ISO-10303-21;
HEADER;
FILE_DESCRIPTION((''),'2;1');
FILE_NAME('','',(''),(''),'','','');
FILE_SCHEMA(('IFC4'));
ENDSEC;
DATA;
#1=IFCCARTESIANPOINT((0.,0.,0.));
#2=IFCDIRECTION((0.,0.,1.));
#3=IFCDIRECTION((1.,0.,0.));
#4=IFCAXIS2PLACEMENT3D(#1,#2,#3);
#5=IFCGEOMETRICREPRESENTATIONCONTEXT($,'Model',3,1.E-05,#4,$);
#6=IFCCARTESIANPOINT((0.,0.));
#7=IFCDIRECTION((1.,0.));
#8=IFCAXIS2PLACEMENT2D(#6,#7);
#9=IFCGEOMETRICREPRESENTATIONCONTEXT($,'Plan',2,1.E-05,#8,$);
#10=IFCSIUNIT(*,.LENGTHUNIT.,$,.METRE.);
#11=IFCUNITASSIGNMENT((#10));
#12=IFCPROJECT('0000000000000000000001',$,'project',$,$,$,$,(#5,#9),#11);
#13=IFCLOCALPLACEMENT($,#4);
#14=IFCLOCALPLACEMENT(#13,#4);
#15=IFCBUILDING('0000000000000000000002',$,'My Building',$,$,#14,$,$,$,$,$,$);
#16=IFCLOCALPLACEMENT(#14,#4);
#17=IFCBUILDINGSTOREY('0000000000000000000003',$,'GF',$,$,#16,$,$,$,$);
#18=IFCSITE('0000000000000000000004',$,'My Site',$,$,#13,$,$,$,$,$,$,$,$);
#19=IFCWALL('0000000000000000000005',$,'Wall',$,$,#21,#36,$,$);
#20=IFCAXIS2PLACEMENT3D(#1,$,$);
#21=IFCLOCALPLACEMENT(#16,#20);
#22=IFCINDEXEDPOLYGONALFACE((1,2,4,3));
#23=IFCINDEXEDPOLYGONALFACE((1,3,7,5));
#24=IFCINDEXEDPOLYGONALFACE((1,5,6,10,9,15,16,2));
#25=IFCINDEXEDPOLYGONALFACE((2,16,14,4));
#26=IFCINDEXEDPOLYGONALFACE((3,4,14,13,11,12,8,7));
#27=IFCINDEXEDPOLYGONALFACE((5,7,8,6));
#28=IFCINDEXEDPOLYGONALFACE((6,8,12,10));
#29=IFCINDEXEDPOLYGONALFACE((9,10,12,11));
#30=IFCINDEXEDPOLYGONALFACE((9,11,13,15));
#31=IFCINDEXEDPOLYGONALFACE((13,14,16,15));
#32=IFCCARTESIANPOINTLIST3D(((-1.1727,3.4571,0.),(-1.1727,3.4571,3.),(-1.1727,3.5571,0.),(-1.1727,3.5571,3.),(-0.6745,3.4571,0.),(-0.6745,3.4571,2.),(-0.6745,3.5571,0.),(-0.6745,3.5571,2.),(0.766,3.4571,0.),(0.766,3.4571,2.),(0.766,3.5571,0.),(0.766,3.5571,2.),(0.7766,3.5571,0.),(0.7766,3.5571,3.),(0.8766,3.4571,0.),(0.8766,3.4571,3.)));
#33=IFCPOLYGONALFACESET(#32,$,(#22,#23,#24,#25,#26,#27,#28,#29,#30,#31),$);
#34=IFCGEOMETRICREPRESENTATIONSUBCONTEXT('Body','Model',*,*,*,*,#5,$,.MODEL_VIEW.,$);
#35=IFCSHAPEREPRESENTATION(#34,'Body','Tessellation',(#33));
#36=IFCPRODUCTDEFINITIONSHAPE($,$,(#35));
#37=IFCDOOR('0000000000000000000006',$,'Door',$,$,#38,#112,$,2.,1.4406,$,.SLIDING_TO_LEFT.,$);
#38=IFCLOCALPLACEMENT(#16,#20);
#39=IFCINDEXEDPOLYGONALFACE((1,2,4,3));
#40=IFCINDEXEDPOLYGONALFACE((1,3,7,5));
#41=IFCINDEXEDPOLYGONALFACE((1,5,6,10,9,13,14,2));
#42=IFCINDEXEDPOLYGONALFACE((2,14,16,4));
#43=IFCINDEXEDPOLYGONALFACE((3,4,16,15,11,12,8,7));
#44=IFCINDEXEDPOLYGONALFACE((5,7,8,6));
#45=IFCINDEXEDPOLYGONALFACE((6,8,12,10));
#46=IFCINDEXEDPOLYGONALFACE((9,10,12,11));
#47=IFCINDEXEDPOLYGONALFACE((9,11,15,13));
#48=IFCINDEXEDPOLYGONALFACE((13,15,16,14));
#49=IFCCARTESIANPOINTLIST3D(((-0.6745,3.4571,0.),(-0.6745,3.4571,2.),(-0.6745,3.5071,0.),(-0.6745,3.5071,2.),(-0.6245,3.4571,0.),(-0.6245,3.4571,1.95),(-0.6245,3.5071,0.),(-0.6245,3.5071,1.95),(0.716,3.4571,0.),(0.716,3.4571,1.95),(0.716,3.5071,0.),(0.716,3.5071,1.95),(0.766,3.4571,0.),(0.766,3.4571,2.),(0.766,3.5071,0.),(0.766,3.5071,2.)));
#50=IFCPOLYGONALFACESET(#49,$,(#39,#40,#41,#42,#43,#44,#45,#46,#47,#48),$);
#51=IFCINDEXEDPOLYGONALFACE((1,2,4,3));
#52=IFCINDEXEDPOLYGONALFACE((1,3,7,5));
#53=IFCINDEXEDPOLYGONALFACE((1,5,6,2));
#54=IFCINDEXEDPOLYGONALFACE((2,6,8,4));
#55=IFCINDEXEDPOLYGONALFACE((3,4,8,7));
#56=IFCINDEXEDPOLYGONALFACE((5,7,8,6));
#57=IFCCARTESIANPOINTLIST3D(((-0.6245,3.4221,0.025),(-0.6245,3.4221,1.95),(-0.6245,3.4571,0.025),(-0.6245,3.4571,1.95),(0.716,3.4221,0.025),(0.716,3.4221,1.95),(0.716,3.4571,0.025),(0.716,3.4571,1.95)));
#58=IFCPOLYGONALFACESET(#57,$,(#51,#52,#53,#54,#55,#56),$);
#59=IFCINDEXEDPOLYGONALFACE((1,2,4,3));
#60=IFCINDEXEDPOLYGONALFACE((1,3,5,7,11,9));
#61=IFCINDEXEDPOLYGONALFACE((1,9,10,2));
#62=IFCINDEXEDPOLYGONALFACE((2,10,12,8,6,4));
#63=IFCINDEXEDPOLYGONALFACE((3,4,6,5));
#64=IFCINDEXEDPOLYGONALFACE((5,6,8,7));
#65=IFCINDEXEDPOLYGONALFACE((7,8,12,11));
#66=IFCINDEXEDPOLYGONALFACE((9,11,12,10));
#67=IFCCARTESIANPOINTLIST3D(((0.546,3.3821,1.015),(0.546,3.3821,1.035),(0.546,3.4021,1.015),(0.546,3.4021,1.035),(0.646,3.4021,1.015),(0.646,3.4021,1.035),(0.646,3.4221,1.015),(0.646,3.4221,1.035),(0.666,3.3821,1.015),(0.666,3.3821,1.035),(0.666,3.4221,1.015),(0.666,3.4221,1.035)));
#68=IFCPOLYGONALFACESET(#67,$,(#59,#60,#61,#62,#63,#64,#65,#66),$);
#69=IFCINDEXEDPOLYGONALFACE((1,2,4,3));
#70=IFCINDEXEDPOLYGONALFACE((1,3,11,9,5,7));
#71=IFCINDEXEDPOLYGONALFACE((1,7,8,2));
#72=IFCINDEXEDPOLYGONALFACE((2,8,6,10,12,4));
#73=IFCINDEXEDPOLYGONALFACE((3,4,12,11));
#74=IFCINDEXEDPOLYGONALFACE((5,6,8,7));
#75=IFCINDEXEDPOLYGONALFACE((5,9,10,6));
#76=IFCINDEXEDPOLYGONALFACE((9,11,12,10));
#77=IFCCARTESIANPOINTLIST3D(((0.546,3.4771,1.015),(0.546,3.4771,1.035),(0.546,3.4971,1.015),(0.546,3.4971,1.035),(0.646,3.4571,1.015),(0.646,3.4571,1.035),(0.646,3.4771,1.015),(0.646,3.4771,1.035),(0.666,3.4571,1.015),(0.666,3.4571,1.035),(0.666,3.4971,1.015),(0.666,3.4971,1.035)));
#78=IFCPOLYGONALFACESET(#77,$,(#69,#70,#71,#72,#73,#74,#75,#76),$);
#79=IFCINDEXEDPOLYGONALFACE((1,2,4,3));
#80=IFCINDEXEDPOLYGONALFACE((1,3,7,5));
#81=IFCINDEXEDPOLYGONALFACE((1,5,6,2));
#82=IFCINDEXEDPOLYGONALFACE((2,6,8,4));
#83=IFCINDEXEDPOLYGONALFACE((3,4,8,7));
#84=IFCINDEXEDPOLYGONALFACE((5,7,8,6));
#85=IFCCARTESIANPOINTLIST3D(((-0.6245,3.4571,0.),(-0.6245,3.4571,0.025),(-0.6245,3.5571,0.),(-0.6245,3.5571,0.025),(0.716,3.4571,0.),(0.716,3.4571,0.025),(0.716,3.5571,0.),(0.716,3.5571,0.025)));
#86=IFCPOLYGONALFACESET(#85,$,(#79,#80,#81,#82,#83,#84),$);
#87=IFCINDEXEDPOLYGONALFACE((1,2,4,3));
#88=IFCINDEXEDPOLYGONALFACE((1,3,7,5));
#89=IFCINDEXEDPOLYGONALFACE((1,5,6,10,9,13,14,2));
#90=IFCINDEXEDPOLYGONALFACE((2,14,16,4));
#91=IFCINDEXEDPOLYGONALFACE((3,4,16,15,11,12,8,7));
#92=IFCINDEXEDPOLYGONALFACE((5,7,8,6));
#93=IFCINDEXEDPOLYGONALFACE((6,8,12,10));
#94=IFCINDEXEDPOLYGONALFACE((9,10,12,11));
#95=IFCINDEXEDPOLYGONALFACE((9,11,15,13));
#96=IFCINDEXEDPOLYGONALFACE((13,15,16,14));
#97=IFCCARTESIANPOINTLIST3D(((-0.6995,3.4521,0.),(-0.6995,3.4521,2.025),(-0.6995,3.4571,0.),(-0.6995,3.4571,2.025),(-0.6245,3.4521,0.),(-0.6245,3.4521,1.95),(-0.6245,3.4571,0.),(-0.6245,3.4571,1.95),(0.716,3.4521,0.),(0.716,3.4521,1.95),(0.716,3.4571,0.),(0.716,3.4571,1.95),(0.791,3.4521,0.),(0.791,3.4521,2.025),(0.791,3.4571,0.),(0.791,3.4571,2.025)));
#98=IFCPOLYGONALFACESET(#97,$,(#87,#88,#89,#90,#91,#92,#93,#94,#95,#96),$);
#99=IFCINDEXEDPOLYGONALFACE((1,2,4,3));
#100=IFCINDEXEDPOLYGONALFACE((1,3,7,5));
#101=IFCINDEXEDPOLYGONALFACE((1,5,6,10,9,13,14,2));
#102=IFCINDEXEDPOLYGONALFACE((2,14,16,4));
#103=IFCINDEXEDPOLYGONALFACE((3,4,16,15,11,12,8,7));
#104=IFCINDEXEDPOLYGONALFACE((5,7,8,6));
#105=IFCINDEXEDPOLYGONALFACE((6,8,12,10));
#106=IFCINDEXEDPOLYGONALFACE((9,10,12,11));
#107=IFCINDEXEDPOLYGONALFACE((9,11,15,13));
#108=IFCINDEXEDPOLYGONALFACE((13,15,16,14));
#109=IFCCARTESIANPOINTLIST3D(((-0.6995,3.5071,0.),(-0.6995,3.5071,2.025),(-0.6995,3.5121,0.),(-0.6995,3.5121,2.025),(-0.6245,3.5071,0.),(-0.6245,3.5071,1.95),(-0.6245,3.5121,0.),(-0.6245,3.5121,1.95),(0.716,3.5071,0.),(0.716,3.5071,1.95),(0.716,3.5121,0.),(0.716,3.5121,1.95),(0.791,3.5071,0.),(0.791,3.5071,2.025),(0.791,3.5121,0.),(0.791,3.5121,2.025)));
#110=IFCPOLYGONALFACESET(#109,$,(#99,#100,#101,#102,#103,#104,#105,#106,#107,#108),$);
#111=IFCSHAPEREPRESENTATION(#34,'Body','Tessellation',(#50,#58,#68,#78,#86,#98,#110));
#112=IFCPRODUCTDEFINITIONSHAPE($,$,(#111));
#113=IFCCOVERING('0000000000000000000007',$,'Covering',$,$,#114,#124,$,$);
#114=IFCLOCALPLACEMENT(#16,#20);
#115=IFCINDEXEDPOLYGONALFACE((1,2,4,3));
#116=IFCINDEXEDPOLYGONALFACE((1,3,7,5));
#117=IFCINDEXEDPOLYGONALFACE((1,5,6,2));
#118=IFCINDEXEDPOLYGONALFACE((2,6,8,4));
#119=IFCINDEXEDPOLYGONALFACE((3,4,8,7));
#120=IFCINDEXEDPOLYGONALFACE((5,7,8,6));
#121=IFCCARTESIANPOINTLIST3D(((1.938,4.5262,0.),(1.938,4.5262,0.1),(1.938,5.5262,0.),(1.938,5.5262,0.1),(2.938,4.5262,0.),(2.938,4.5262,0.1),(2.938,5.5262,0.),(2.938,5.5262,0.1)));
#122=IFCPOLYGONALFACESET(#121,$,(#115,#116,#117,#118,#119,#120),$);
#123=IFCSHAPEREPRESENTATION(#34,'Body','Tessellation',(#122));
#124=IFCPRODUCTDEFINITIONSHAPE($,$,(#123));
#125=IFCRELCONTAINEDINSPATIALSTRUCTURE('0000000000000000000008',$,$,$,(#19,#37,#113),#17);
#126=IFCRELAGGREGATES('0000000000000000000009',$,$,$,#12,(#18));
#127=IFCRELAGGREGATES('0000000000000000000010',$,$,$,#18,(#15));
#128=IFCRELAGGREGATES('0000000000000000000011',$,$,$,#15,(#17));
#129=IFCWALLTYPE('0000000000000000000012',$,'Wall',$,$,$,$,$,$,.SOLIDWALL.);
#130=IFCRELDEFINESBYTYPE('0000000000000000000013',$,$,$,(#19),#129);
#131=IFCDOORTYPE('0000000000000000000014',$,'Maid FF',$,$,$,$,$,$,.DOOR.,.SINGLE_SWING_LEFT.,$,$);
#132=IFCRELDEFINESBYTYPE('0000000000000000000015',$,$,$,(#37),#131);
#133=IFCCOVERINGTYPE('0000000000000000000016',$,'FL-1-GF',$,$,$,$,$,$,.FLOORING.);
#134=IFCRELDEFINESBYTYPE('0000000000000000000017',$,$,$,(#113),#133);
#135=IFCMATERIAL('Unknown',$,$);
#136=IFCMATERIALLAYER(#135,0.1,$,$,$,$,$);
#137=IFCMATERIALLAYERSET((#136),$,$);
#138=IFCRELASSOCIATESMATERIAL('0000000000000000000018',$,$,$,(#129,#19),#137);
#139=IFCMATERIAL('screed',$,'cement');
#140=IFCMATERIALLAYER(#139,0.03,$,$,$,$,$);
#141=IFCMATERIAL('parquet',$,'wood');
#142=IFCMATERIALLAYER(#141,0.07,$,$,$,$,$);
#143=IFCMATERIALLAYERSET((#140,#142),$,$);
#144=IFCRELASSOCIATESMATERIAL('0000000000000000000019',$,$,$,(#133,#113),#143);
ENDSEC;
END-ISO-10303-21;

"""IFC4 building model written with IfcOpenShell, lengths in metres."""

from ifc_helpers import new_model, entity, si_unit, frame, origin_with_axes, origin_2d_with_axis, place, context, subcontext, project, spatial, line, indexed_curve, outline, extrude, shape, source, transform, mapped, material, layer, layer_set, layer_usage, type_object, type_shapes, element, fill, save


model = new_model("IFC4")

# Units and contexts
model_context = context("Model", 3, precision=1e-05, world=origin_with_axes())
plan_context = context("Plan", 2, precision=1e-05, world=origin_2d_with_axis())
body_context_1 = subcontext(model_context, "Body", "Model", "MODEL_VIEW")
body_context_2 = subcontext(plan_context, "Body", "Plan", "PLAN_VIEW")
ifc_project = project(units=[si_unit("LENGTHUNIT", "METRE")], contexts=[model_context, plan_context])

# Site, building, storey
site_placement = place(None, origin_with_axes())
site = spatial("IfcSite", under=ifc_project, at=site_placement, Name="My Site")
building_placement = place(site_placement, origin_with_axes())
building = spatial("IfcBuilding", under=site, at=building_placement, Name="My Building")
storey_placement = place(building_placement, origin_with_axes())
storey = spatial("IfcBuildingStorey", under=building, at=storey_placement, Name="GF")

# Shared definitions
ifc_material_1 = material(Name="Unknown")

# Shared definitions
ifc_layer_1 = layer(ifc_material_1, 0.1)
ifc_layer_set_1 = layer_set([ifc_layer_1])
wall_type = type_object("IfcWallType", Name="Wall", PredefinedType="SOLIDWALL", material=ifc_layer_set_1)

# Wall, opening, door
ifc_layer_usage_1 = layer_usage(ifc_layer_set_1, "AXIS2", "POSITIVE", 0.0)
wall_1_placement = place(storey_placement, frame((0.7766, 3.5571, 0.0), z_axis=(0.0, 0.0, 1.0), x_axis=(-1.0, 0.0, 0.0)))
wall_1 = element("IfcWall", 1, at=wall_1_placement, inside=storey, type_object=wall_type, material=ifc_layer_usage_1, Name="Wall", context=body_context_1, shape_type="SweptSolid", body=[
    extrude(outline(indexed_curve([(0.0, 0.0), (-0.1, 0.1), (1.9493, 0.1), (1.9493, 0.0)], segments=[line(1, 2, 3, 4, 1)])), origin_with_axes(), (0.0, 0.0, 1.0), 3.0),
])
shared_shape_1 = source(origin_with_axes(), body_context_1, "Body", "SweptSolid", [
    extrude(outline(indexed_curve([(0.0, 0.0), (1.4406, 0.0), (1.4406, 2.0), (0.0, 2.0)], segments=[line(1, 2, 3, 4, 1)])), frame((0.0, -0.6, 0.0), z_axis=(0.0, -1.0, 0.0), x_axis=(1.0, 0.0, 0.0)), (0.0, 0.0, -1.0), 1.2),
])
opening_1_placement = place(wall_1_placement, frame((1.4511, 0.1, 0.0), z_axis=(0.0, 0.0, 1.0), x_axis=(-1.0, 0.000001, 0.0)))
opening_1 = element("IfcOpeningElement", 2, at=opening_1_placement, cuts=wall_1, PredefinedType="OPENING", context=body_context_1, shape_type="MappedRepresentation", body=[
    mapped(shared_shape_1, transform((0.0, 0.0, 0.0), x_axis=(1.0, 0.0, 0.0), y_axis=(0.0, 1.0, 0.0), z_axis=(0.0, 0.0, 1.0), scale=1.0)),
])
door_type_1 = type_object("IfcDoorType", Name="Maid FF", OperationType="SINGLE_SWING_LEFT", PredefinedType="DOOR")
shared_shape_2 = source(origin_with_axes(), body_context_1, "Body", "SweptSolid", [
    extrude(outline(indexed_curve([(0.0, 0.0), (0.0, 2.0), (1.4406, 2.0), (1.4406, 0.0), (1.3906, 0.0), (1.3906, 1.95), (0.05, 1.95), (0.05, 0.0)], segments=[line(1, 2, 3, 4, 5, 6, 7, 8, 1)])), frame((0.0, 0.0, 0.0), z_axis=(0.0, -1.0, 0.0), x_axis=(1.0, 0.0, 0.0)), (0.0, 0.0, -1.0), 0.05),
    extrude(outline(indexed_curve([(0.0, 0.0), (1.3406, 0.0), (1.3406, 0.035), (0.0, 0.035)], segments=[line(1, 2, 3, 4, 1)])), frame((0.05, -0.035, 0.025), z_axis=(0.0, 0.0, 1.0), x_axis=(1.0, 0.0, 0.0)), (0.0, 0.0, 1.0), 1.925),
    extrude(outline(indexed_curve([(0.0, 0.0), (0.0, -0.04), (-0.12, -0.04), (-0.12, -0.02), (-0.02, -0.02), (-0.02, 0.0)], segments=[line(1, 2, 3, 4, 5, 6, 1)])), frame((1.3406, -0.035, 1.015), z_axis=(0.0, 0.0, 1.0), x_axis=(1.0, 0.0, 0.0)), (0.0, 0.0, 1.0), 0.02),
    extrude(outline(indexed_curve([(0.0, 0.0), (0.0, 0.04), (-0.12, 0.04), (-0.12, 0.02), (-0.02, 0.02), (-0.02, 0.0)], segments=[line(1, 2, 3, 4, 5, 6, 1)])), frame((1.3406, 0.0, 1.015), z_axis=(0.0, 0.0, 1.0), x_axis=(1.0, 0.0, 0.0)), (0.0, 0.0, 1.0), 0.02),
    extrude(outline(indexed_curve([(0.0, 0.0), (1.3406, 0.0), (1.3406, 0.1), (0.0, 0.1)], segments=[line(1, 2, 3, 4, 1)])), frame((0.05, 0.0, 0.0), z_axis=(0.0, 0.0, 1.0), x_axis=(1.0, 0.0, 0.0)), (0.0, 0.0, 1.0), 0.025),
    extrude(outline(indexed_curve([(0.0, 0.0), (0.0, 2.025), (1.4906, 2.025), (1.4906, 0.0), (1.4156, 0.0), (1.4156, 1.95), (0.075, 1.95), (0.075, 0.0)], segments=[line(1, 2, 3, 4, 5, 6, 7, 8, 1)])), frame((-0.025, -0.005, 0.0), z_axis=(0.0, -1.0, 0.0), x_axis=(1.0, 0.0, 0.0)), (0.0, 0.0, -1.0), 0.005),
    extrude(outline(indexed_curve([(0.0, 0.0), (0.0, 2.025), (1.4906, 2.025), (1.4906, 0.0), (1.4156, 0.0), (1.4156, 1.95), (0.075, 1.95), (0.075, 0.0)], segments=[line(1, 2, 3, 4, 5, 6, 7, 8, 1)])), frame((-0.025, 0.05, 0.0), z_axis=(0.0, -1.0, 0.0), x_axis=(1.0, 0.0, 0.0)), (0.0, 0.0, -1.0), 0.005),
])
shared_shape_3 = source(origin_with_axes(), body_context_2, "Body", "Curve2D", [
    entity("IfcIndexedPolyCurve", entity("IfcCartesianPointList2D", [[0.0, 0.0], [0.05, 0.0], [0.05, 0.05], [0.0, 0.05]]), [entity("IfcLineIndex", [1, 2, 3, 4, 1])]),
    entity("IfcIndexedPolyCurve", entity("IfcCartesianPointList2D", [[1.4406, 0.0], [1.3906, 0.0], [1.3906, 0.05], [1.4406, 0.05]]), [entity("IfcLineIndex", [1, 2, 3, 4, 1])]),
    entity("IfcIndexedPolyCurve", entity("IfcCartesianPointList2D", [[-0.6203, -0.035], [0.7203, -0.035], [0.7203, 0.0], [-0.6203, 0.0]]), [entity("IfcLineIndex", [1, 2, 3, 4, 1])]),
])
type_shapes(door_type_1, [shared_shape_2, shared_shape_3])
door_1_placement = place(opening_1_placement, frame((0.0, 0.0, 0.0), z_axis=(0.0, 0.0, 1.0), x_axis=(1.0, 0.0, 0.0)))
door_1 = element("IfcDoor", 3, at=door_1_placement, inside=storey, type_object=door_type_1, Name="Door", OperationType="SLIDING_TO_LEFT", OverallHeight=2.0, OverallWidth=1.4406, shapes=[
    shape(body_context_1, "Body", "MappedRepresentation", [mapped(shared_shape_2, transform((0.0, 0.0, 0.0), x_axis=(1.0, 0.0, 0.0), y_axis=(0.0, 1.0, 0.0), z_axis=(0.0, 0.0, 1.0), scale=1.0))]),
    shape(body_context_2, "Body", "MappedRepresentation", [mapped(shared_shape_3, transform((0.0, 0.0, 0.0), x_axis=(1.0, 0.0, 0.0), y_axis=(0.0, 1.0, 0.0), z_axis=(0.0, 0.0, 1.0), scale=1.0))]),
])
fill(opening_1, door_1)

# Covering
ifc_material_2 = material(Name="screed", Category="cement")
ifc_layer_2 = layer(ifc_material_2, 0.03)
ifc_material_3 = material(Name="parquet", Category="wood")
ifc_layer_3 = layer(ifc_material_3, 0.07)
ifc_layer_set_2 = layer_set([ifc_layer_2, ifc_layer_3])
ifc_layer_usage_2 = layer_usage(ifc_layer_set_2, "AXIS3", "POSITIVE", 0.0)
covering_type = type_object("IfcCoveringType", Name="FL-1-GF", PredefinedType="FLOORING", material=ifc_layer_set_2)
covering_placement = place(storey_placement, frame((1.938, 4.5262, 0.0), z_axis=(0.0, 0.0, 1.0), x_axis=(1.0, 0.0, 0.0)))
element("IfcCovering", 4, at=covering_placement, inside=storey, type_object=covering_type, material=ifc_layer_usage_2, Name="Covering", context=body_context_1, shape_type="SweptSolid", body=[
    extrude(outline(indexed_curve([(0.0, 0.0), (1.0, 0.0), (1.0, 1.0), (0.0, 1.0), (0.0, 0.0)])), origin_with_axes(), (0.0, 0.0, 1.0), 0.1),
])

save(model, "model.ifc")
